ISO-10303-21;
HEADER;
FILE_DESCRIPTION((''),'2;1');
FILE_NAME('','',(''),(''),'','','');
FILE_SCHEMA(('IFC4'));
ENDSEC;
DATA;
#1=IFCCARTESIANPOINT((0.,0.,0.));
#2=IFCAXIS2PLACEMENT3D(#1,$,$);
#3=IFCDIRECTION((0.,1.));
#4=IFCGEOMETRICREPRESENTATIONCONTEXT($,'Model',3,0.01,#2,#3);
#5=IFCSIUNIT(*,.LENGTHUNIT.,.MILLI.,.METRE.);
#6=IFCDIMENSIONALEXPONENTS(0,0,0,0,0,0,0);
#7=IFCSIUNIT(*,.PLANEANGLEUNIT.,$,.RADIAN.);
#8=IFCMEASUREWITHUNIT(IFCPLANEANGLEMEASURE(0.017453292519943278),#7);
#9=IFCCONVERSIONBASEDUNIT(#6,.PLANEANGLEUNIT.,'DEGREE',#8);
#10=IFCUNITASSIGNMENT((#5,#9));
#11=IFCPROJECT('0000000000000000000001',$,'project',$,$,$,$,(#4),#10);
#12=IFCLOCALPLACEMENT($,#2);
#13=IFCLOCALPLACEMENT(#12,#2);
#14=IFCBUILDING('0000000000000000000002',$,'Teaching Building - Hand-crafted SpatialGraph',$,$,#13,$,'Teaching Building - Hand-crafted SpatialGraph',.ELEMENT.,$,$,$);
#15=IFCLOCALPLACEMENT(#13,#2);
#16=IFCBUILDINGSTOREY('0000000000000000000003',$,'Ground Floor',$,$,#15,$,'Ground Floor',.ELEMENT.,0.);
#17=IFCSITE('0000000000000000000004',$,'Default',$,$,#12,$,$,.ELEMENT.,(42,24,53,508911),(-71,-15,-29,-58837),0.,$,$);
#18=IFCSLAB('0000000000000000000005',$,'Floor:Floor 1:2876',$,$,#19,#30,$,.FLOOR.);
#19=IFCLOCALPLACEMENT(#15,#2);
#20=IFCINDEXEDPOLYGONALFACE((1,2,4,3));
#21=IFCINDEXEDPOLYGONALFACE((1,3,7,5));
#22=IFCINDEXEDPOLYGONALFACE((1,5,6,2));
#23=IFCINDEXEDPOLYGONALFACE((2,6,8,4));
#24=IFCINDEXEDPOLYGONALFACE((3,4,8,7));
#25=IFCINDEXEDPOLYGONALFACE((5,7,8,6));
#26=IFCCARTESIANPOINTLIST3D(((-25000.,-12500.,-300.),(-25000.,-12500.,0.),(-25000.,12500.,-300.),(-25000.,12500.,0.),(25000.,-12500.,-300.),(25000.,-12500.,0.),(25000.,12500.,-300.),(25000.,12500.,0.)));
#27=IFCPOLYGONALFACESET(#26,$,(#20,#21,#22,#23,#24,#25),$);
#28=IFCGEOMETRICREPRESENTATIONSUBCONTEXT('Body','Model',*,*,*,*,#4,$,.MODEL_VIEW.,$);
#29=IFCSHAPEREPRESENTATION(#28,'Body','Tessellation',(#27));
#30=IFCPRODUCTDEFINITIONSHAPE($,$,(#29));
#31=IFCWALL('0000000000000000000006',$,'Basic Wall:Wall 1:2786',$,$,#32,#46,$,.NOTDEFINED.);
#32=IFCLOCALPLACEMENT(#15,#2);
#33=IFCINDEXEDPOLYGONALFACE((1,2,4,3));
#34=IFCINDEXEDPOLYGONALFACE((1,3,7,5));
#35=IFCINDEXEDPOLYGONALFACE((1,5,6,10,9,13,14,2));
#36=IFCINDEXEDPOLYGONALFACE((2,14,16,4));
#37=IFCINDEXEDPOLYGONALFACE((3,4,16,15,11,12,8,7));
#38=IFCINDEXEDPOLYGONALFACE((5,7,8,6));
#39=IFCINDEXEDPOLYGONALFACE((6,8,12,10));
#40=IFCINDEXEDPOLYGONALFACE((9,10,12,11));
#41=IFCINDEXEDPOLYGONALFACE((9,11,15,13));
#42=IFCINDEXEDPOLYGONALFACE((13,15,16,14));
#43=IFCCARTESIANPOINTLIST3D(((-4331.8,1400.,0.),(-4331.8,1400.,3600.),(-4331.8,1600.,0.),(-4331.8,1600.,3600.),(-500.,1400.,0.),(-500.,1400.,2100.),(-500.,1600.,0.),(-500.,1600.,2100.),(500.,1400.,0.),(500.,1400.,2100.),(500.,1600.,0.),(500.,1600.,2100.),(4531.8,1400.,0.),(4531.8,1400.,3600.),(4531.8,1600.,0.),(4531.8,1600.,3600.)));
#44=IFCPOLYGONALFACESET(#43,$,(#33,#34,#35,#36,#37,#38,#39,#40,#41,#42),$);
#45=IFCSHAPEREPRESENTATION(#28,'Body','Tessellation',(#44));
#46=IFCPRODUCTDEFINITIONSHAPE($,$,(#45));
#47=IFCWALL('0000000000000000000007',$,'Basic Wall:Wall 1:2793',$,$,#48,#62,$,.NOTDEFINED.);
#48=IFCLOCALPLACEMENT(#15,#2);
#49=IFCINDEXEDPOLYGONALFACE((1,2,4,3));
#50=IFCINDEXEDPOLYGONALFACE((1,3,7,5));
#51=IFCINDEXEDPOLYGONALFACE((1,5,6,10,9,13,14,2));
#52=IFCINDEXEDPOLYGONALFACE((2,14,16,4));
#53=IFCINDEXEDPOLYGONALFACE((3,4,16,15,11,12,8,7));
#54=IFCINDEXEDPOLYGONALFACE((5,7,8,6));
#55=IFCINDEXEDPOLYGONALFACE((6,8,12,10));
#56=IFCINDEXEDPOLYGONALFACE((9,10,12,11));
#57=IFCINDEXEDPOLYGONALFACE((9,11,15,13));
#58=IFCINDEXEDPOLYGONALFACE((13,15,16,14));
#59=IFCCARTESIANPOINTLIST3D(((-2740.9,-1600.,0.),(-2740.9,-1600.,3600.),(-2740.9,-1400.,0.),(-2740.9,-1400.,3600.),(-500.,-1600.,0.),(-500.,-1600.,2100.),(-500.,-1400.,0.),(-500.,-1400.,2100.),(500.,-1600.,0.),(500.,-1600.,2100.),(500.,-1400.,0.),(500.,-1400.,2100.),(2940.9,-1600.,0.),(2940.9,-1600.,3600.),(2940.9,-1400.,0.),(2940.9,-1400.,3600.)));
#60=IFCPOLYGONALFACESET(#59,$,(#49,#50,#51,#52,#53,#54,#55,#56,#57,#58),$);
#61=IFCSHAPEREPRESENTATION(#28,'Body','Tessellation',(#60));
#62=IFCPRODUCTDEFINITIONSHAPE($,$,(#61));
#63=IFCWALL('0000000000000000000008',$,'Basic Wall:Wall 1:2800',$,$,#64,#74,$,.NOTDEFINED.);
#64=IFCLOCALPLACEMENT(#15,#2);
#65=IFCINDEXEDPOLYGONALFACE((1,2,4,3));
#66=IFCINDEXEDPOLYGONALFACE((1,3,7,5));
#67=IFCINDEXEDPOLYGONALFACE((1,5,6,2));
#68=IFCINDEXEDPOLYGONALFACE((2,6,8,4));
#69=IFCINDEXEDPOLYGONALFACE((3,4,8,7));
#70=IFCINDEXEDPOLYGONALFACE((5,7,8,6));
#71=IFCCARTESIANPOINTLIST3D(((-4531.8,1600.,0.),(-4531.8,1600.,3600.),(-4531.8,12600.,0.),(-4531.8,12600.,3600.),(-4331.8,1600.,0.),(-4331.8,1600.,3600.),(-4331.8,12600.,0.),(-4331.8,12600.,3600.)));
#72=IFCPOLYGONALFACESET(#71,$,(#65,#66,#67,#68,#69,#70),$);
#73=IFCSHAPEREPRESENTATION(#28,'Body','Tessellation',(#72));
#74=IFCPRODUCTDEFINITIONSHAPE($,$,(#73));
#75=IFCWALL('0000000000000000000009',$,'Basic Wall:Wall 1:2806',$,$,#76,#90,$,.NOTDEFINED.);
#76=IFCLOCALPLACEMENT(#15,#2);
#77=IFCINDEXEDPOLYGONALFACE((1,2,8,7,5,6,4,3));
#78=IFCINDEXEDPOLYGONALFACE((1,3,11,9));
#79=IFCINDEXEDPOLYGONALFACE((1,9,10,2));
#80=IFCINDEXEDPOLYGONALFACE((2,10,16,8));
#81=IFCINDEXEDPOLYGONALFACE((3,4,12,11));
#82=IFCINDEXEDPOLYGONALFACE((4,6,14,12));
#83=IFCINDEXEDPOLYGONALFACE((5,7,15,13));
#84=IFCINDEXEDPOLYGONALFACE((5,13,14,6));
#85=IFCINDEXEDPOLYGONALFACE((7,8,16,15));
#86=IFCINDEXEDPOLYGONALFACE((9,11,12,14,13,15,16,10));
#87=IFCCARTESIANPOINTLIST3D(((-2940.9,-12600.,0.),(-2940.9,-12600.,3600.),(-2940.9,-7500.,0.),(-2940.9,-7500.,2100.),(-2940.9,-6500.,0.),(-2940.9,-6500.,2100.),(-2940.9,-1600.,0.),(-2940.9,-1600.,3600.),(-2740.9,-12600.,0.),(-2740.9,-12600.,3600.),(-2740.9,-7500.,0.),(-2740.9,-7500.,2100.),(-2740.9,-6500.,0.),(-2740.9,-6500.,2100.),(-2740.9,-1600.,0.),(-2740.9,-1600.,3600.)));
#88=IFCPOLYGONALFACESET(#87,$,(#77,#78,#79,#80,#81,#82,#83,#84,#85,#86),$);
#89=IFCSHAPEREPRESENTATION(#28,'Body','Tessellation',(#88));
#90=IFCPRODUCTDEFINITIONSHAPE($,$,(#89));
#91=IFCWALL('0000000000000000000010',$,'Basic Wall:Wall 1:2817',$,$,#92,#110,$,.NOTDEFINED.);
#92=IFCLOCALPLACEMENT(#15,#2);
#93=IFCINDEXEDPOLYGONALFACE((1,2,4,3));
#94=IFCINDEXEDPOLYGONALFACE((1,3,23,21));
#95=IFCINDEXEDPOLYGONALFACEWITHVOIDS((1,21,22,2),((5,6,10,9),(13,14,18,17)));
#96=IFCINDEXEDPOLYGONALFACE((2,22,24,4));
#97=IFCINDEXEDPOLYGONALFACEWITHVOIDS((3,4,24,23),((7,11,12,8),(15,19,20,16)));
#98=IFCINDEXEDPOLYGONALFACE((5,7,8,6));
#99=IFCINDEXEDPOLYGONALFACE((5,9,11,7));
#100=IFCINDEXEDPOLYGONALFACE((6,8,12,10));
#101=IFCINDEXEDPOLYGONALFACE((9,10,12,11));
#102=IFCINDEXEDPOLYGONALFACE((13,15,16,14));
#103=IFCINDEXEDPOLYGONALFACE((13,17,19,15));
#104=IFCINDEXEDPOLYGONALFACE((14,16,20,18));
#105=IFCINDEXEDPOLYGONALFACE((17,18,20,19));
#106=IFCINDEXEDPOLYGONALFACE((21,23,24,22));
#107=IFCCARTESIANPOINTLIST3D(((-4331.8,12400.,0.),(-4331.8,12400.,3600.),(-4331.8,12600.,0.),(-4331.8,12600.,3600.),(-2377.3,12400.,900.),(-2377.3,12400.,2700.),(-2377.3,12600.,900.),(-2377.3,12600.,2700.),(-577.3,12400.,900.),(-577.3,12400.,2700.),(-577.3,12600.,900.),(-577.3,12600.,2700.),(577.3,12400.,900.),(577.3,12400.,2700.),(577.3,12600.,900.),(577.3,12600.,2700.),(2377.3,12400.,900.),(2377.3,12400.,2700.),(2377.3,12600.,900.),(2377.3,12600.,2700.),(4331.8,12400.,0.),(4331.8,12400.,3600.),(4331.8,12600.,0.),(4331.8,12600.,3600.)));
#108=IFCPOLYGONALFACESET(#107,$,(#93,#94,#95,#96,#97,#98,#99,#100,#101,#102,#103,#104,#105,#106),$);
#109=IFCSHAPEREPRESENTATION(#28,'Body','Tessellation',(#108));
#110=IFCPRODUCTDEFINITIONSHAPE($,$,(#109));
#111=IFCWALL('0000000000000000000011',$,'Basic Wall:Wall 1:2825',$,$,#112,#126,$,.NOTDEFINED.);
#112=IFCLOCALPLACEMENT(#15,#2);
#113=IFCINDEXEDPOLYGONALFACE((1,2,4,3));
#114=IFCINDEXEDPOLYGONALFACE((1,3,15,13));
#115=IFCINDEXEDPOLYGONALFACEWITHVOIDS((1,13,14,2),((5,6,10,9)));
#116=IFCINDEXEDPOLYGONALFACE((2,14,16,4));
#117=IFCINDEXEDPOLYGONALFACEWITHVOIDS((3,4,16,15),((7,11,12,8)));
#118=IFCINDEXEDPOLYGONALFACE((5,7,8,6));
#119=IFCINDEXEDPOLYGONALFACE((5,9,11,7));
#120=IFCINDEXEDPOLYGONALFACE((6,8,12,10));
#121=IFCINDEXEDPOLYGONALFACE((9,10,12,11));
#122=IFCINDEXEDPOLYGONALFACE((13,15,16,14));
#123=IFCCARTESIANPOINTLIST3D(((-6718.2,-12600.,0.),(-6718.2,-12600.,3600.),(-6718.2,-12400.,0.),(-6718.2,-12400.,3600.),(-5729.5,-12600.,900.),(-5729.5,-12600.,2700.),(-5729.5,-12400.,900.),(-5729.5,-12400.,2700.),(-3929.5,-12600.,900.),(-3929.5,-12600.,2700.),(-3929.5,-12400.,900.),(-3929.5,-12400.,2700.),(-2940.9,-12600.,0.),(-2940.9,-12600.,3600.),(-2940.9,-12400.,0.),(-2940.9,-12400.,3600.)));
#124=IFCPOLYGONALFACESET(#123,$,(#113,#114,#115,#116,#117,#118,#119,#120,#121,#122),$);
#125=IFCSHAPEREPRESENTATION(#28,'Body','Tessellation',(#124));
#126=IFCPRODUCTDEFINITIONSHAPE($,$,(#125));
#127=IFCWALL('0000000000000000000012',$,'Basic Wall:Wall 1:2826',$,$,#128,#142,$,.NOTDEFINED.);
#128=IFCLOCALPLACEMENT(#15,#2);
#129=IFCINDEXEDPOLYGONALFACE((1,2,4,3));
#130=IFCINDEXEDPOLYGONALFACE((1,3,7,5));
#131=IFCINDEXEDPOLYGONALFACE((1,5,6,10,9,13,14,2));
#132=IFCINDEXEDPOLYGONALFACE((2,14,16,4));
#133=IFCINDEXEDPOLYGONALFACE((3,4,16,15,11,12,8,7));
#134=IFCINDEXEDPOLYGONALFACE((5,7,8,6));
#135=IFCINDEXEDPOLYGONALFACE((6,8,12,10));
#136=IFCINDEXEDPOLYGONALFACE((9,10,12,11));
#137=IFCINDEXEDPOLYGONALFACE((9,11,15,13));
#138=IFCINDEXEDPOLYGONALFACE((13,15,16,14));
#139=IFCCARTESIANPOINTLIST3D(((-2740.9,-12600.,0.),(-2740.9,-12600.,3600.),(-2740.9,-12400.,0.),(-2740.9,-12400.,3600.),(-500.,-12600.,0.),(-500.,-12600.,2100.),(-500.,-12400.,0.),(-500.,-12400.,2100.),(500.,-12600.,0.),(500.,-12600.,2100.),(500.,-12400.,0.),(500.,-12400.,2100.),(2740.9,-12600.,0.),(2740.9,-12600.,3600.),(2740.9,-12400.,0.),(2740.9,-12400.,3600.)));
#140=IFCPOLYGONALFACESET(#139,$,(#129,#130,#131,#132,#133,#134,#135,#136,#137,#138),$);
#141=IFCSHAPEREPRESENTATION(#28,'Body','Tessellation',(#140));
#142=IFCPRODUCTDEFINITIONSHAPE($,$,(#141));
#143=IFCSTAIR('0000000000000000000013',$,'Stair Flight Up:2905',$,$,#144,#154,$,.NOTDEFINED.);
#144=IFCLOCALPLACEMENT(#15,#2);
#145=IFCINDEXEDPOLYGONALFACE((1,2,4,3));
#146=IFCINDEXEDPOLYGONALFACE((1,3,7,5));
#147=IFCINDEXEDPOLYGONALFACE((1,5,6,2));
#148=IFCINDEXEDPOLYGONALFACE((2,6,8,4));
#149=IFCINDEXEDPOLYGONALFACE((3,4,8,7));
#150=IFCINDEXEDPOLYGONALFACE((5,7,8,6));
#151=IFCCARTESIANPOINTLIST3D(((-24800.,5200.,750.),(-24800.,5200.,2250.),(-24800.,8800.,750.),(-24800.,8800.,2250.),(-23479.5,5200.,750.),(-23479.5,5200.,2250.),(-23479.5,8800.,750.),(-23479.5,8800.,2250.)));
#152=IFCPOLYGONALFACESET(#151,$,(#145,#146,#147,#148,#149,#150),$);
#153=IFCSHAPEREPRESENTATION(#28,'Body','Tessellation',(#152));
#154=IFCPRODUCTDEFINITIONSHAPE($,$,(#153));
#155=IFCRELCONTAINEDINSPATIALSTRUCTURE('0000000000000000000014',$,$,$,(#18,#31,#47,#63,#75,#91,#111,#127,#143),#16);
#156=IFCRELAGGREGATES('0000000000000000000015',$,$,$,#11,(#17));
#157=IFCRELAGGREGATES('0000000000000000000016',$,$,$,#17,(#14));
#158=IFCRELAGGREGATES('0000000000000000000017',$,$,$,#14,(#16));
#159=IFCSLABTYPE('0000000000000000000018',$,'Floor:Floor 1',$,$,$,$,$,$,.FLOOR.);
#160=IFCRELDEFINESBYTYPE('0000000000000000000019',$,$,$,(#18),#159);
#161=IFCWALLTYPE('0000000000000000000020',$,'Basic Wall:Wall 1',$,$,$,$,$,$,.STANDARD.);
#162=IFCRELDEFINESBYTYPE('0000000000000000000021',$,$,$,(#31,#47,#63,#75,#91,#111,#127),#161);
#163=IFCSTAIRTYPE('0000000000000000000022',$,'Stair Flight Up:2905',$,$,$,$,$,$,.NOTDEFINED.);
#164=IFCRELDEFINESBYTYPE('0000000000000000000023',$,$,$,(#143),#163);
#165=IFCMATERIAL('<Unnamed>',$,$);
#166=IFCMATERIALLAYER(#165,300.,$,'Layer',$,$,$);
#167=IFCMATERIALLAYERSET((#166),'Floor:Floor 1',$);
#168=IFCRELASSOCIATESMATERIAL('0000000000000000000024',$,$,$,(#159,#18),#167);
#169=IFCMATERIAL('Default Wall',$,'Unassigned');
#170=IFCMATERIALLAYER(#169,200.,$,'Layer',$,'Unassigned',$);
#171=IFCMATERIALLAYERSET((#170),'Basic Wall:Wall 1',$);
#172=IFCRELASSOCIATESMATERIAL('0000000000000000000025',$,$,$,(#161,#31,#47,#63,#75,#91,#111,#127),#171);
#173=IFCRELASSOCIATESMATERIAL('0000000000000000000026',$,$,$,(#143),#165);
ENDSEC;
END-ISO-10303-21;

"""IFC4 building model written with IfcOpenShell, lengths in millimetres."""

from ifc_helpers import new_model, entity, si_unit, converted_unit, direction, frame, frame_2d, origin, origin_2d_with_axis, place, context, subcontext, project, spatial, rectangle, extrude, material, layer, layer_set, layer_usage, type_object, element, save


model = new_model("IFC4")

# Units and contexts
model_context = context("Model", 3, precision=0.01, world=origin(), true_north=direction((0.0, 1.0)))
body_context = subcontext(model_context, "Body", "Model", "MODEL_VIEW")
ifc_project = project(units=[si_unit("LENGTHUNIT", "METRE", prefix="MILLI"), converted_unit("PLANEANGLEUNIT", "DEGREE", entity("IfcPlaneAngleMeasure", 0.017453292519943278), si_unit("PLANEANGLEUNIT", "RADIAN"), dimensions=[0, 0, 0, 0, 0, 0, 0])], contexts=[model_context])

# Site, building, storey
site_placement = place(None, origin())
site = spatial("IfcSite", under=ifc_project, at=site_placement, Name="Default", CompositionType="ELEMENT", RefLatitude=(42, 24, 53, 508911), RefLongitude=(-71, -15, -29, -58837), RefElevation=0.0)
building_placement = place(site_placement, origin())
building = spatial("IfcBuilding", under=site, at=building_placement, Name="Teaching Building - Hand-crafted SpatialGraph", LongName="Teaching Building - Hand-crafted SpatialGraph", CompositionType="ELEMENT")
storey_placement = place(building_placement, origin())
storey = spatial("IfcBuildingStorey", under=building, at=storey_placement, Name="Ground Floor", LongName="Ground Floor", CompositionType="ELEMENT", Elevation=0.0)

# Slab
ifc_material_1 = material(Name="<Unnamed>")
ifc_layer_1 = layer(ifc_material_1, 300.0, Name="Layer")
ifc_layer_set_1 = layer_set([ifc_layer_1], Name="Floor:Floor 1")
ifc_layer_usage_1 = layer_usage(ifc_layer_set_1, "AXIS3", "POSITIVE", 0.0)
slab_type = type_object("IfcSlabType", Name="Floor:Floor 1", PredefinedType="FLOOR", material=ifc_layer_set_1)
slab_placement = place(storey_placement, origin())
element("IfcSlab", 1, at=slab_placement, inside=storey, type_object=slab_type, material=ifc_layer_usage_1, Name="Floor:Floor 1:2876", PredefinedType="FLOOR", context=body_context, shape_type="SweptSolid", body=[
    extrude(rectangle(XDim=25000.0, YDim=50000.0, at=origin_2d_with_axis()), frame((0.0, 0.0, 0.0), z_axis=(0.0, 0.0, -1.0), x_axis=(0.0, 1.0, 0.0)), (0.0, 0.0, 1.0), 300.0),
])

# Walls, openings
ifc_material_2 = material(Name="Default Wall", Category="Unassigned")
ifc_layer_2 = layer(ifc_material_2, 200.0, Name="Layer", Category="Unassigned")
ifc_layer_set_2 = layer_set([ifc_layer_2], Name="Basic Wall:Wall 1")
ifc_layer_usage_2 = layer_usage(ifc_layer_set_2, "AXIS2", "NEGATIVE", 100.0)
wall_type = type_object("IfcWallType", Name="Basic Wall:Wall 1", PredefinedType="STANDARD", material=ifc_layer_set_2)
wall_1_placement = place(storey_placement, frame((-4331.8, 1500.0, 0.0)))
wall_1 = element("IfcWall", 2, at=wall_1_placement, inside=storey, type_object=wall_type, material=ifc_layer_usage_2, Name="Basic Wall:Wall 1:2786", PredefinedType="NOTDEFINED", context=body_context, shape_type="SweptSolid", body=[
    extrude(rectangle(XDim=8863.6, YDim=200.0, at=frame_2d((4431.8, 0.0), x_axis=(1.0, 0.0))), origin(), (0.0, 0.0, 1.0), 3600.0),
])
opening_1_placement = place(wall_1_placement, origin())
element("IfcOpeningElement", 3, at=opening_1_placement, cuts=wall_1, PredefinedType="OPENING", context=body_context, shape_type="SweptSolid", body=[
    extrude(rectangle(XDim=2100.0, YDim=1000.0, at=origin_2d_with_axis()), frame((4331.8, -100.0, 1050.0), z_axis=(0.0, 1.0, 0.0), x_axis=(0.0, 0.0, -1.0)), (0.0, 0.0, 1.0), 200.0),
])
ifc_layer_usage_3 = layer_usage(ifc_layer_set_2, "AXIS2", "NEGATIVE", 100.0)
wall_2_placement = place(storey_placement, frame((-2740.9, -1500.0, 0.0)))
wall_2 = element("IfcWall", 4, at=wall_2_placement, inside=storey, type_object=wall_type, material=ifc_layer_usage_3, Name="Basic Wall:Wall 1:2793", PredefinedType="NOTDEFINED", context=body_context, shape_type="SweptSolid", body=[
    extrude(rectangle(XDim=5681.8, YDim=200.0, at=frame_2d((2840.9, 0.0), x_axis=(1.0, 0.0))), origin(), (0.0, 0.0, 1.0), 3600.0),
])
opening_2_placement = place(wall_2_placement, origin())
element("IfcOpeningElement", 5, at=opening_2_placement, cuts=wall_2, PredefinedType="OPENING", context=body_context, shape_type="SweptSolid", body=[
    extrude(rectangle(XDim=2100.0, YDim=1000.0, at=origin_2d_with_axis()), frame((2740.9, -100.0, 1050.0), z_axis=(0.0, 1.0, 0.0), x_axis=(0.0, 0.0, -1.0)), (0.0, 0.0, 1.0), 200.0),
])

# Wall
ifc_layer_usage_4 = layer_usage(ifc_layer_set_2, "AXIS2", "NEGATIVE", 100.0)
wall_3_placement = place(storey_placement, frame((-4431.8, 1600.0, 0.0), z_axis=(0.0, 0.0, 1.0), x_axis=(0.0, 1.0, 0.0)))
element("IfcWall", 6, at=wall_3_placement, inside=storey, type_object=wall_type, material=ifc_layer_usage_4, Name="Basic Wall:Wall 1:2800", PredefinedType="NOTDEFINED", context=body_context, shape_type="SweptSolid", body=[
    extrude(rectangle(XDim=11000.0, YDim=200.0, at=frame_2d((5500.0, 0.0), x_axis=(-1.0, 0.0))), origin(), (0.0, 0.0, 1.0), 3600.0),
])

# Wall, opening
ifc_layer_usage_5 = layer_usage(ifc_layer_set_2, "AXIS2", "NEGATIVE", 100.0)
wall_4_placement = place(storey_placement, frame((-2840.9, -12600.0, 0.0), z_axis=(0.0, 0.0, 1.0), x_axis=(0.0, 1.0, 0.0)))
wall_4 = element("IfcWall", 7, at=wall_4_placement, inside=storey, type_object=wall_type, material=ifc_layer_usage_5, Name="Basic Wall:Wall 1:2806", PredefinedType="NOTDEFINED", context=body_context, shape_type="SweptSolid", body=[
    extrude(rectangle(XDim=11000.0, YDim=200.0, at=frame_2d((5500.0, 0.0), x_axis=(1.0, 0.0))), origin(), (0.0, 0.0, 1.0), 3600.0),
])
opening_3_placement = place(wall_4_placement, origin())
element("IfcOpeningElement", 8, at=opening_3_placement, cuts=wall_4, PredefinedType="OPENING", context=body_context, shape_type="SweptSolid", body=[
    extrude(rectangle(XDim=2100.0, YDim=1000.0, at=origin_2d_with_axis()), frame((5600.0, -100.0, 1050.0), z_axis=(0.0, 1.0, 0.0), x_axis=(0.0, 0.0, -1.0)), (0.0, 0.0, 1.0), 200.0),
])

# Wall, openings
ifc_layer_usage_6 = layer_usage(ifc_layer_set_2, "AXIS2", "NEGATIVE", 100.0)
wall_5_placement = place(storey_placement, frame((-4331.8, 12500.0, 0.0)))
wall_5 = element("IfcWall", 9, at=wall_5_placement, inside=storey, type_object=wall_type, material=ifc_layer_usage_6, Name="Basic Wall:Wall 1:2817", PredefinedType="NOTDEFINED", context=body_context, shape_type="SweptSolid", body=[
    extrude(rectangle(XDim=8663.6, YDim=200.0, at=frame_2d((4331.8, 0.0), x_axis=(-1.0, 0.0))), origin(), (0.0, 0.0, 1.0), 3600.0),
])
opening_4_placement = place(wall_5_placement, origin())
element("IfcOpeningElement", 10, at=opening_4_placement, cuts=wall_5, PredefinedType="OPENING", context=body_context, shape_type="SweptSolid", body=[
    extrude(rectangle(XDim=1800.0, YDim=1800.0, at=origin_2d_with_axis()), frame((2854.5, -100.0, 1800.0), z_axis=(0.0, 1.0, 0.0), x_axis=(0.0, 0.0, -1.0)), (0.0, 0.0, 1.0), 200.0),
])
opening_5_placement = place(wall_5_placement, origin())
element("IfcOpeningElement", 11, at=opening_5_placement, cuts=wall_5, PredefinedType="OPENING", context=body_context, shape_type="SweptSolid", body=[
    extrude(rectangle(XDim=1800.0, YDim=1800.0, at=origin_2d_with_axis()), frame((5809.1, -100.0, 1800.0), z_axis=(0.0, 1.0, 0.0), x_axis=(0.0, 0.0, -1.0)), (0.0, 0.0, 1.0), 200.0),
])

# Walls, openings
ifc_layer_usage_7 = layer_usage(ifc_layer_set_2, "AXIS2", "NEGATIVE", 100.0)
wall_6_placement = place(storey_placement, frame((-6718.2, -12500.0, 0.0)))
wall_6 = element("IfcWall", 12, at=wall_6_placement, inside=storey, type_object=wall_type, material=ifc_layer_usage_7, Name="Basic Wall:Wall 1:2825", PredefinedType="NOTDEFINED", context=body_context, shape_type="SweptSolid", body=[
    extrude(rectangle(XDim=3777.3, YDim=200.0, at=frame_2d((1888.6, 0.0), x_axis=(-1.0, 0.0))), origin(), (0.0, 0.0, 1.0), 3600.0),
])
opening_6_placement = place(wall_6_placement, origin())
element("IfcOpeningElement", 13, at=opening_6_placement, cuts=wall_6, PredefinedType="OPENING", context=body_context, shape_type="SweptSolid", body=[
    extrude(rectangle(XDim=1800.0, YDim=1800.0, at=origin_2d_with_axis()), frame((1888.6, -100.0, 1800.0), z_axis=(0.0, 1.0, 0.0), x_axis=(0.0, 0.0, -1.0)), (0.0, 0.0, 1.0), 200.0),
])
ifc_layer_usage_8 = layer_usage(ifc_layer_set_2, "AXIS2", "NEGATIVE", 100.0)
wall_7_placement = place(storey_placement, frame((-2740.9, -12500.0, 0.0)))
wall_7 = element("IfcWall", 14, at=wall_7_placement, inside=storey, type_object=wall_type, material=ifc_layer_usage_8, Name="Basic Wall:Wall 1:2826", PredefinedType="NOTDEFINED", context=body_context, shape_type="SweptSolid", body=[
    extrude(rectangle(XDim=5481.8, YDim=200.0, at=frame_2d((2740.9, 0.0), x_axis=(1.0, 0.0))), origin(), (0.0, 0.0, 1.0), 3600.0),
])
opening_7_placement = place(wall_7_placement, origin())
element("IfcOpeningElement", 15, at=opening_7_placement, cuts=wall_7, PredefinedType="OPENING", context=body_context, shape_type="SweptSolid", body=[
    extrude(rectangle(XDim=2100.0, YDim=1000.0, at=origin_2d_with_axis()), frame((2740.9, -100.0, 1050.0), z_axis=(0.0, 1.0, 0.0), x_axis=(0.0, 0.0, -1.0)), (0.0, 0.0, 1.0), 200.0),
])

# Stair
stair_type_1 = type_object("IfcStairType", Name="Stair Flight Up:2905", PredefinedType="NOTDEFINED")
stair_1_placement = place(storey_placement, origin())
element("IfcStair", 16, at=stair_1_placement, inside=storey, type_object=stair_type_1, material=ifc_material_1, Name="Stair Flight Up:2905", PredefinedType="NOTDEFINED", context=body_context, shape_type="SweptSolid", body=[
    extrude(rectangle(XDim=1320.5, YDim=3600.0, at=origin_2d_with_axis()), frame((-24139.8, 7000.0, 750.0)), (0.0, 0.0, 1.0), 1500.0),
])

save(model, "model.ifc")
